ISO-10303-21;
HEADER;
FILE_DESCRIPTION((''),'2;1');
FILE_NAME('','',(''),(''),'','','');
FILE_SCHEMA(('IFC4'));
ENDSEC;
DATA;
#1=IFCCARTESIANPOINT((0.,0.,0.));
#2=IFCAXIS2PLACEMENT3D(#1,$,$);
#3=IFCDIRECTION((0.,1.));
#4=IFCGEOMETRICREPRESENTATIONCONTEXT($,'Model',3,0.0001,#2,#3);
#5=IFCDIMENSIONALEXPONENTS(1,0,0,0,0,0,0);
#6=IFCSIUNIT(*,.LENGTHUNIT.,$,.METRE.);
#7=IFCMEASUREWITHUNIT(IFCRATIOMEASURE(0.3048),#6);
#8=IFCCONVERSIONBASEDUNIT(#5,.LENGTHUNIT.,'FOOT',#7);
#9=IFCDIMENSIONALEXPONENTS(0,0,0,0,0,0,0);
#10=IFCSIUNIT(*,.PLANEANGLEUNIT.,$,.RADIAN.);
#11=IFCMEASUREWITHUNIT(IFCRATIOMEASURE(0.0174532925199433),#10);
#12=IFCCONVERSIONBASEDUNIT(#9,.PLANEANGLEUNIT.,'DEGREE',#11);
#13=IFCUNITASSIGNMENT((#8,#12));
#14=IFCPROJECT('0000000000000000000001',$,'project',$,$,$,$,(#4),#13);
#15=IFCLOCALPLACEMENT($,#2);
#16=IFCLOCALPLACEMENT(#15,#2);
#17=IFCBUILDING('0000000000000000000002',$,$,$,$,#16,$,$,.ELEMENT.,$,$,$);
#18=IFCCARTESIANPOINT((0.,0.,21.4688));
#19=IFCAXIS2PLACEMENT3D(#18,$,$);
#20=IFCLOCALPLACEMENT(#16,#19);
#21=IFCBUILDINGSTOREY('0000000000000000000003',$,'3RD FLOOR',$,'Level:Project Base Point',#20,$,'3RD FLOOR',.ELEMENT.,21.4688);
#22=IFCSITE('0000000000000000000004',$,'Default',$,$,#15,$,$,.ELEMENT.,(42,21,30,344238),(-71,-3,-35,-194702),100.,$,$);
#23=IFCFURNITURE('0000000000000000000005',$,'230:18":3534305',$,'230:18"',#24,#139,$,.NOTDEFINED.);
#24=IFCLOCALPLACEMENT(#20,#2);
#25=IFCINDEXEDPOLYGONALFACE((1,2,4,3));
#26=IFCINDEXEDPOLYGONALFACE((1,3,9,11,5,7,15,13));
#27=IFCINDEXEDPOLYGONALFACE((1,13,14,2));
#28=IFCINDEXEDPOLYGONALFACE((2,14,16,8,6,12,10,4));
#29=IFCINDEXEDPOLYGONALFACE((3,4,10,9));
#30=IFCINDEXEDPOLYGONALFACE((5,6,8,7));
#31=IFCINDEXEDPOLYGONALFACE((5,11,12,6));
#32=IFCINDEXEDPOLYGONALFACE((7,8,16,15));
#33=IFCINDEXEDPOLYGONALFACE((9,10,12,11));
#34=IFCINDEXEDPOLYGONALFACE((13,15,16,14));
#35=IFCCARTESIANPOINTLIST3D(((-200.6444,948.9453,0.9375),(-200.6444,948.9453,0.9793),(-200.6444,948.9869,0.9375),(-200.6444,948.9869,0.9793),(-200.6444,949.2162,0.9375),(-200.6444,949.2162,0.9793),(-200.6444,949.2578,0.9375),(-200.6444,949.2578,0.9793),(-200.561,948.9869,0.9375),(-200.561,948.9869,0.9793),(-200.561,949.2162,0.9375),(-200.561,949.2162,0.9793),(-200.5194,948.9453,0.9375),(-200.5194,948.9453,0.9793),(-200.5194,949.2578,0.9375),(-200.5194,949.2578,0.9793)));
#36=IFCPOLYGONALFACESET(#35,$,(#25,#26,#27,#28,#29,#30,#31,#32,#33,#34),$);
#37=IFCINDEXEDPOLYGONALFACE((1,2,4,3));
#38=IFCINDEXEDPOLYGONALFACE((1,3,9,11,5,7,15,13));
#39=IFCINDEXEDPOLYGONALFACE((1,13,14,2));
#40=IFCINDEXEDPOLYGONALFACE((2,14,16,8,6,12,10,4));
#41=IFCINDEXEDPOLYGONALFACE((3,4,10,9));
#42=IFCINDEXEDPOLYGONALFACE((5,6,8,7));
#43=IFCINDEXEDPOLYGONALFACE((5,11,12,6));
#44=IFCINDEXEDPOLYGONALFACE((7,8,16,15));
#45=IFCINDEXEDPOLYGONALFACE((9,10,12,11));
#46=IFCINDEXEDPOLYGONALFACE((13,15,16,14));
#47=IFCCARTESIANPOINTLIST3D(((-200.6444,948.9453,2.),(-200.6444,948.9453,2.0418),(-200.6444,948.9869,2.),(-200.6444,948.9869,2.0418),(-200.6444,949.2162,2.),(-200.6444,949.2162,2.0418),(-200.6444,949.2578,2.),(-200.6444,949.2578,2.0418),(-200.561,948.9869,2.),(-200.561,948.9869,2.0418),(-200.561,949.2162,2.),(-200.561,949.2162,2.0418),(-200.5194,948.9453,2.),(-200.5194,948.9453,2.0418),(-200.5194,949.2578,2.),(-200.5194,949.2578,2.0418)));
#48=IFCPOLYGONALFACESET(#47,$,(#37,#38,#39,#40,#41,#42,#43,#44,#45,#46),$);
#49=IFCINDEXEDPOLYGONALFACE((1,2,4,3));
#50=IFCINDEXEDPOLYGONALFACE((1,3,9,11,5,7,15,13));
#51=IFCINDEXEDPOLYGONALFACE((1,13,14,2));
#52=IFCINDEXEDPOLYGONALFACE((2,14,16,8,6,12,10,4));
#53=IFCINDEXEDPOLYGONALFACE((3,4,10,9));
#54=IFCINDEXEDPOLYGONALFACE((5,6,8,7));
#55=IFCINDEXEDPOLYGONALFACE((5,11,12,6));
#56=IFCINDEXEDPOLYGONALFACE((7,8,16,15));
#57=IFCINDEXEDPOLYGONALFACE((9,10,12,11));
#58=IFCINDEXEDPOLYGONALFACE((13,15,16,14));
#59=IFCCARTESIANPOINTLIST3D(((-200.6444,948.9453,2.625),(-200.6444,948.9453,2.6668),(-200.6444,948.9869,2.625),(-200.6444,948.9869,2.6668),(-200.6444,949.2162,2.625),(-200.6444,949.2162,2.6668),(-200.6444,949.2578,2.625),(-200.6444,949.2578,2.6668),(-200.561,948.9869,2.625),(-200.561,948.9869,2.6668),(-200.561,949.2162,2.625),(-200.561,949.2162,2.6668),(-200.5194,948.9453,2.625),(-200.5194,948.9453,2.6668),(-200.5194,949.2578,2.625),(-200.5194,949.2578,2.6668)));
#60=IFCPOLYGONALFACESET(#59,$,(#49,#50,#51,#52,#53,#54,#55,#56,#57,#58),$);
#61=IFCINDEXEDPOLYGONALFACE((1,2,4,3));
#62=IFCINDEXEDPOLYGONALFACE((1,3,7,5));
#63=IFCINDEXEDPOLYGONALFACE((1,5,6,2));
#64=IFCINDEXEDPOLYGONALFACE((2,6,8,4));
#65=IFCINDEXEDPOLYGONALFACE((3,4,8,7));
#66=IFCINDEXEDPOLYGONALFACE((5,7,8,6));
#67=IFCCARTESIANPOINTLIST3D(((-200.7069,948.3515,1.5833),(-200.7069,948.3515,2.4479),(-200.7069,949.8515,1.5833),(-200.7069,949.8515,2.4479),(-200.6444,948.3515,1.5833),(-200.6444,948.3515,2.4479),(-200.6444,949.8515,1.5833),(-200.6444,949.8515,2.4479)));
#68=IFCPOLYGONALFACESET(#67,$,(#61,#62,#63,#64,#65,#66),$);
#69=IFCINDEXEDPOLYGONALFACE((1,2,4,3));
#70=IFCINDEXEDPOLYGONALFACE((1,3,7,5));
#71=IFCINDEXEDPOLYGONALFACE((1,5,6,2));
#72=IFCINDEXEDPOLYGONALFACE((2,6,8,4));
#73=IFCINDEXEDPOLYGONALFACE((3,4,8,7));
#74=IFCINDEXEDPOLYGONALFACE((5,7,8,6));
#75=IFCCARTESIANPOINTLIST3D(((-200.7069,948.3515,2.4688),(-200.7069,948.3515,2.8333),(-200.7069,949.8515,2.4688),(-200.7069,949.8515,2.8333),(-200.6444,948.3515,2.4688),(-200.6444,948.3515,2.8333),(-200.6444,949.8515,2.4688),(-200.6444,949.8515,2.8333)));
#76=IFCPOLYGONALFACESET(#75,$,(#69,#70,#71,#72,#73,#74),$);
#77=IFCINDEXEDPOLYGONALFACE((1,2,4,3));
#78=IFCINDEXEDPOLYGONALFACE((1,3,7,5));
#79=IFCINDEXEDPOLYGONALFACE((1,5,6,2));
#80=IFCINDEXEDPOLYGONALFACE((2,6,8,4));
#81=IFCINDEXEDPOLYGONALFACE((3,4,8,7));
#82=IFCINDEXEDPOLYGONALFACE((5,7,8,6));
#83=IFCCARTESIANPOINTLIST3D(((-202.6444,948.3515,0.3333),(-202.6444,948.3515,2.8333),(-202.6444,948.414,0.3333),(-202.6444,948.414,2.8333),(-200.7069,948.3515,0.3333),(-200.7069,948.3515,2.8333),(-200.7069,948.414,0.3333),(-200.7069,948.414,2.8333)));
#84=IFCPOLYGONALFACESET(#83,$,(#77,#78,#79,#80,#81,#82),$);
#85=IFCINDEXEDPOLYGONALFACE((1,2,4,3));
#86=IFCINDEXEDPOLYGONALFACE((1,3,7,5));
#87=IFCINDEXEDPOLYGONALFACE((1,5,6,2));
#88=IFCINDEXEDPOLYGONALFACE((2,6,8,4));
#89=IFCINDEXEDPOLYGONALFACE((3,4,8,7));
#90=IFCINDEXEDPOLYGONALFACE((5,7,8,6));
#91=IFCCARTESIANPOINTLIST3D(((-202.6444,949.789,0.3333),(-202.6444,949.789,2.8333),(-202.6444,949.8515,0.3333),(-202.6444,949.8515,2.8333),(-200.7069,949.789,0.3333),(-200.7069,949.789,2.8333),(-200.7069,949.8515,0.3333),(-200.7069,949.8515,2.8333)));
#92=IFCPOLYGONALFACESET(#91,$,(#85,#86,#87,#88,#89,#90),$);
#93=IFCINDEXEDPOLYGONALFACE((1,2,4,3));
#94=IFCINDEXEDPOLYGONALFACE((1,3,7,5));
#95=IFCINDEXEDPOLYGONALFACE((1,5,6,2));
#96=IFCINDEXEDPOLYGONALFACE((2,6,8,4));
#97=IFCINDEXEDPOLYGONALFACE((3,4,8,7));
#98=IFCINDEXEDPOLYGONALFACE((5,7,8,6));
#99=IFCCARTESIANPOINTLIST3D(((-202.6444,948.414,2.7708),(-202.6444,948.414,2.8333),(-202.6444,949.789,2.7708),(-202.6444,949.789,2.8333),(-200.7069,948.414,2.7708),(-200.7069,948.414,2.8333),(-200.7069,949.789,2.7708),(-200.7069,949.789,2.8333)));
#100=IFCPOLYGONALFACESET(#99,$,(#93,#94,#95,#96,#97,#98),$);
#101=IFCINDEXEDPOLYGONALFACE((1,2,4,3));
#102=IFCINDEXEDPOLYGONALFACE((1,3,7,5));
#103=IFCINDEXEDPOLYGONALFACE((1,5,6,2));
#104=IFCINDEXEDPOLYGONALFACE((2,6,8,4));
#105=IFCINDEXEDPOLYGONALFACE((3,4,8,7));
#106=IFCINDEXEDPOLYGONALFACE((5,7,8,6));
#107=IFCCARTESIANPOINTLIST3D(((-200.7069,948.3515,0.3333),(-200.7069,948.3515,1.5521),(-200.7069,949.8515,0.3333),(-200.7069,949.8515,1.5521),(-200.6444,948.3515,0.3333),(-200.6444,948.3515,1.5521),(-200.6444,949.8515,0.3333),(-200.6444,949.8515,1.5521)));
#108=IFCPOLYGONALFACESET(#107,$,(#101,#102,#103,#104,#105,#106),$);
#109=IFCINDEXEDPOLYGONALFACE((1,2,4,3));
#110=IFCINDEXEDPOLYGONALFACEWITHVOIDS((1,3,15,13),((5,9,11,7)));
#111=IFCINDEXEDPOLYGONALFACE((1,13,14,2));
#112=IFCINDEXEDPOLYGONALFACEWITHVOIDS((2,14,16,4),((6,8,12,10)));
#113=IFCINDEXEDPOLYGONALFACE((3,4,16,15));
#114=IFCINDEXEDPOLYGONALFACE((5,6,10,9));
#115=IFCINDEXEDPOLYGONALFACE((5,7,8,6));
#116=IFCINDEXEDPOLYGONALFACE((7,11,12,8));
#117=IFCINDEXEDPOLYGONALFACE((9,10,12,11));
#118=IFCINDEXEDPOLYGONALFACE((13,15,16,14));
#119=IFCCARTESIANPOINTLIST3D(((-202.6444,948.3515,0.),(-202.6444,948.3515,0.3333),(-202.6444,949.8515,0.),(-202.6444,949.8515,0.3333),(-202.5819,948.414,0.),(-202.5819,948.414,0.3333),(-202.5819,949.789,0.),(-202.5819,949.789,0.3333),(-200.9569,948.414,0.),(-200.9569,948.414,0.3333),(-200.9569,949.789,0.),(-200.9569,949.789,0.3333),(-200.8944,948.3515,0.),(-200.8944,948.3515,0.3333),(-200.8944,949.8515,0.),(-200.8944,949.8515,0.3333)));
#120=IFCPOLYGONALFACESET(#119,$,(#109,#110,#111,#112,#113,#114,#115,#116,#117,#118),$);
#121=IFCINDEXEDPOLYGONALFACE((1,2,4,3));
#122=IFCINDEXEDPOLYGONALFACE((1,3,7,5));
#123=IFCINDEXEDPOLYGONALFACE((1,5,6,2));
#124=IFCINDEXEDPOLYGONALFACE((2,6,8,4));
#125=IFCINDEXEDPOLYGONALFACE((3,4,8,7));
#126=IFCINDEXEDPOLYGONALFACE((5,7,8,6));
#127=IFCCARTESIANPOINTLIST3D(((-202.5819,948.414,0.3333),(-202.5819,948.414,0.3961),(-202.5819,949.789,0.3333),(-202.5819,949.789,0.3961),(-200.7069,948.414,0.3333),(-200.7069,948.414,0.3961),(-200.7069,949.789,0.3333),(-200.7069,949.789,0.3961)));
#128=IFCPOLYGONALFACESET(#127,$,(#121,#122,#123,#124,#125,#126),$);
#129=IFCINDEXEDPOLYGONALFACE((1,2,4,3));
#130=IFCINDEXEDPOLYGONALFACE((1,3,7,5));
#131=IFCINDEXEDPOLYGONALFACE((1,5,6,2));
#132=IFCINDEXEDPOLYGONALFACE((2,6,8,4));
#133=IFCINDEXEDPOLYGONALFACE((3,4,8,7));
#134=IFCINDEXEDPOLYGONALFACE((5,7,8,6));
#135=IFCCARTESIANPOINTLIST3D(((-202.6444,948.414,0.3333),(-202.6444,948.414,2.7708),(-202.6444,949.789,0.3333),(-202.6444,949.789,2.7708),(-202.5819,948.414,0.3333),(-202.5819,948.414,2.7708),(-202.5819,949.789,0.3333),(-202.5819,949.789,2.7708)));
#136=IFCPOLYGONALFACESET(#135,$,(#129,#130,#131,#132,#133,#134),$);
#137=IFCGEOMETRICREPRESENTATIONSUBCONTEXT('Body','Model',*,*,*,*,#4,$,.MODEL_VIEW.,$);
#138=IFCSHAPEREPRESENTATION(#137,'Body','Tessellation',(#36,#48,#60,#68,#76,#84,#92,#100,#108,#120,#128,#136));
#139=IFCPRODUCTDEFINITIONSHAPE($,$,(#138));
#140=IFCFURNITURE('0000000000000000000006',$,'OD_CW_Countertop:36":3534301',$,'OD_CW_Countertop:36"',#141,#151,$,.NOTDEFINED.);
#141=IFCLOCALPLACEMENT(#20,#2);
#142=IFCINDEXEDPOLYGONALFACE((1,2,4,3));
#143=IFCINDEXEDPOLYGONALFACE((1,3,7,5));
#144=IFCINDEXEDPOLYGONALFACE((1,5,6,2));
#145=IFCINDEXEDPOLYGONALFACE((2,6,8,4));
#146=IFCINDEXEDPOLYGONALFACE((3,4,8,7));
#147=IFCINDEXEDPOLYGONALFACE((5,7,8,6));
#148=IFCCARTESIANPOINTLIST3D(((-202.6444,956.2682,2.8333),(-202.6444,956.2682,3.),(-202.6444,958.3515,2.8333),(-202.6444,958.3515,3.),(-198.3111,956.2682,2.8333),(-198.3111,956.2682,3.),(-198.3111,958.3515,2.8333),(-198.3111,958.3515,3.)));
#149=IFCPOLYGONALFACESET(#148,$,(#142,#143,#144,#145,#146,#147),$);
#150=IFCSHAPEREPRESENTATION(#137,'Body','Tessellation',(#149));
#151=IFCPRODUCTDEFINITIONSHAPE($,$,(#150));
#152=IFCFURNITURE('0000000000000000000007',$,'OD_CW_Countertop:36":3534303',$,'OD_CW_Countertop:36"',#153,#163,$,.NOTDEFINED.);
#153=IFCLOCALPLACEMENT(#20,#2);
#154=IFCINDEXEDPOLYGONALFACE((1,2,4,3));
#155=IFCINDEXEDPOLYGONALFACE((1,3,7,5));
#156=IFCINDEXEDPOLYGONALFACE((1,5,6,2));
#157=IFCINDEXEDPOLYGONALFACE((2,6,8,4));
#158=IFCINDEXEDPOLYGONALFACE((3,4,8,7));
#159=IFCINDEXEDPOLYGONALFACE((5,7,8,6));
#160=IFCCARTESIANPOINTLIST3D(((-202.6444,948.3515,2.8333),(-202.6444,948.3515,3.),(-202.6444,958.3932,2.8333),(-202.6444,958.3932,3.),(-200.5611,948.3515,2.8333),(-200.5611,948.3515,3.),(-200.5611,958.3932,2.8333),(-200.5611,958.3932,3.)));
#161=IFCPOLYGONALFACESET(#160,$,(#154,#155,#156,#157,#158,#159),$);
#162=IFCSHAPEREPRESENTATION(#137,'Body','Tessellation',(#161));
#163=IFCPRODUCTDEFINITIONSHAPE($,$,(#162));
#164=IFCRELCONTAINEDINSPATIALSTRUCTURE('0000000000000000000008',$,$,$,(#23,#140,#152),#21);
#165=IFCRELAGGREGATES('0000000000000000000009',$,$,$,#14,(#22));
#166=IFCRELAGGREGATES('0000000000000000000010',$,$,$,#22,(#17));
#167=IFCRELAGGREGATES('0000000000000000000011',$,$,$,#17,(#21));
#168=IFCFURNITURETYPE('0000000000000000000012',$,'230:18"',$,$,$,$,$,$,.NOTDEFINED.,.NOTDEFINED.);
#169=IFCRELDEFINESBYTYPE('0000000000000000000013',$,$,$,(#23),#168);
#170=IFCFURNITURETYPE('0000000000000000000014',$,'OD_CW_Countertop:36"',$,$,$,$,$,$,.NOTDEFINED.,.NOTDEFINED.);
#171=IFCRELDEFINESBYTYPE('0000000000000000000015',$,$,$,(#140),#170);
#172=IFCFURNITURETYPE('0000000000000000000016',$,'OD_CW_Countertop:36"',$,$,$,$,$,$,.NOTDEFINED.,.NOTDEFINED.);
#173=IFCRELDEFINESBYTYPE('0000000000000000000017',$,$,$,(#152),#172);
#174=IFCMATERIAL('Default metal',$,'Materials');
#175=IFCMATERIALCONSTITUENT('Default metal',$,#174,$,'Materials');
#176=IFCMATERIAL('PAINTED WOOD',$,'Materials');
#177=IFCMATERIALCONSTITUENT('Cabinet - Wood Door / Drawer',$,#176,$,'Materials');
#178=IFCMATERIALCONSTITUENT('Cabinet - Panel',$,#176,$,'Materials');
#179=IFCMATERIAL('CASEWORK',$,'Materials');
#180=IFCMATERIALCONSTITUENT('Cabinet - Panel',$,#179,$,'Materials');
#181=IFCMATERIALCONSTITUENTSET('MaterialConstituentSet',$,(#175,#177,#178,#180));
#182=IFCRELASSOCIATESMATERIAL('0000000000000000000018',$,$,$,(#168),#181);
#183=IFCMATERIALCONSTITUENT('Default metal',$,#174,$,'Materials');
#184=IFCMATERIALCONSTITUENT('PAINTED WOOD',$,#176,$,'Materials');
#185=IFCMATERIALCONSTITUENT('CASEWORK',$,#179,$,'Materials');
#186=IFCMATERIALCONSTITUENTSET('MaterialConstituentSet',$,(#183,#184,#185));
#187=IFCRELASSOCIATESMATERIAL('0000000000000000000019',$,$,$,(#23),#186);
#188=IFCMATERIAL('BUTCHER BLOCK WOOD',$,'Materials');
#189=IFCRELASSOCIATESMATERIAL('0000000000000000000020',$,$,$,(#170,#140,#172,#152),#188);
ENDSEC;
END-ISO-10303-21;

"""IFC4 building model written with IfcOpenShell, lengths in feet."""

from ifc_helpers import new_model, entity, si_unit, converted_unit, direction, frame, frame_2d, origin, origin_2d_with_axis, place, context, subcontext, project, spatial, polyline, rectangle, outline, extrude, source, transform, mapped, material, constituent, constituent_set, type_object, type_shapes, element, save


model = new_model("IFC4")

# Units and contexts
model_context = context("Model", 3, precision=0.0001, world=origin(), true_north=direction((0.0, 1.0)))
body_context = subcontext(model_context, "Body", "Model", "MODEL_VIEW")
ifc_project = project(units=[converted_unit("LENGTHUNIT", "FOOT", entity("IfcRatioMeasure", 0.3048), si_unit("LENGTHUNIT", "METRE"), dimensions=[1, 0, 0, 0, 0, 0, 0]), converted_unit("PLANEANGLEUNIT", "DEGREE", entity("IfcRatioMeasure", 0.0174532925199433), si_unit("PLANEANGLEUNIT", "RADIAN"), dimensions=[0, 0, 0, 0, 0, 0, 0])], contexts=[model_context])

# Site, building, storey
site_placement = place(None, origin())
site = spatial("IfcSite", under=ifc_project, at=site_placement, Name="Default", CompositionType="ELEMENT", RefLatitude=(42, 21, 30, 344238), RefLongitude=(-71, -3, -35, -194702), RefElevation=100.0)
building_placement = place(site_placement, origin())
building = spatial("IfcBuilding", under=site, at=building_placement, CompositionType="ELEMENT")
storey_placement = place(building_placement, frame((0.0, 0.0, 21.4688)))
storey = spatial("IfcBuildingStorey", under=building, at=storey_placement, Name="3RD FLOOR", ObjectType="Level:Project Base Point", LongName="3RD FLOOR", CompositionType="ELEMENT", Elevation=21.4688)

# Furniture
ifc_material_1 = material(Name="Default metal", Category="Materials")
ifc_material_2 = material(Name="PAINTED WOOD", Category="Materials")
ifc_material_3 = material(Name="CASEWORK", Category="Materials")
ifc_constituent_1 = constituent(ifc_material_1, Name="Default metal", Category="Materials")
ifc_constituent_2 = constituent(ifc_material_2, Name="PAINTED WOOD", Category="Materials")
ifc_constituent_3 = constituent(ifc_material_3, Name="CASEWORK", Category="Materials")
ifc_constituent_set_1 = constituent_set(constituents=[ifc_constituent_1, ifc_constituent_2, ifc_constituent_3], Name="MaterialConstituentSet")
ifc_constituent_4 = constituent(ifc_material_1, Name="Default metal", Category="Materials")
ifc_constituent_5 = constituent(ifc_material_2, Name="Cabinet - Wood Door / Drawer", Category="Materials")
ifc_constituent_6 = constituent(ifc_material_2, Name="Cabinet - Panel", Category="Materials")
ifc_constituent_7 = constituent(ifc_material_3, Name="Cabinet - Panel", Category="Materials")
ifc_constituent_set_2 = constituent_set(constituents=[ifc_constituent_4, ifc_constituent_5, ifc_constituent_6, ifc_constituent_7], Name="MaterialConstituentSet")
furniture_type_1 = type_object("IfcFurnitureType", Name="230:18\"", AssemblyPlace="NOTDEFINED", PredefinedType="NOTDEFINED", material=ifc_constituent_set_2)
shared_shape_1 = source(origin(), body_context, "Body", "SweptSolid", [
    extrude(outline(polyline([(-0.0521, -0.1562), (0.0729, -0.1562), (0.0729, 0.1562), (-0.0521, 0.1562), (-0.0521, 0.1146), (0.0313, 0.1146), (0.0313, -0.1146), (-0.0521, -0.1146), (-0.0521, -0.1562)])), frame((0.0615, -2.0521, 0.9375), z_axis=(0.0, 0.0, 1.0), x_axis=(0.0, -1.0, 0.0)), (0.0, 0.0, 1.0), 0.0418),
    extrude(outline(polyline([(-0.0521, -0.1562), (0.0729, -0.1562), (0.0729, 0.1562), (-0.0521, 0.1562), (-0.0521, 0.1146), (0.0313, 0.1146), (0.0313, -0.1146), (-0.0521, -0.1146), (-0.0521, -0.1562)])), frame((0.0615, -2.0521, 2.0), z_axis=(0.0, 0.0, 1.0), x_axis=(0.0, -1.0, 0.0)), (0.0, 0.0, 1.0), 0.0418),
    extrude(outline(polyline([(-0.0521, -0.1562), (0.0729, -0.1562), (0.0729, 0.1562), (-0.0521, 0.1562), (-0.0521, 0.1146), (0.0313, 0.1146), (0.0313, -0.1146), (-0.0521, -0.1146), (-0.0521, -0.1562)])), frame((0.0615, -2.0521, 2.625), z_axis=(0.0, 0.0, 1.0), x_axis=(0.0, -1.0, 0.0)), (0.0, 0.0, 1.0), 0.0418),
    extrude(rectangle(XDim=0.0625, YDim=1.5, at=frame_2d((0.0, 0.0), x_axis=(1.0, 0.0))), frame((0.0615, -1.9688, 1.5833), z_axis=(0.0, 0.0, 1.0), x_axis=(0.0, 1.0, 0.0)), (0.0, 0.0, 1.0), 0.8646),
    extrude(rectangle(XDim=0.0625, YDim=1.5, at=frame_2d((0.0, 0.0), x_axis=(1.0, 0.0))), frame((0.0615, -1.9688, 2.4688), z_axis=(0.0, 0.0, 1.0), x_axis=(0.0, 1.0, 0.0)), (0.0, 0.0, 1.0), 0.3646),
    extrude(rectangle(XDim=0.0625, YDim=1.9375, at=frame_2d((0.0, 0.0), x_axis=(1.0, 0.0))), frame((-0.6573, -0.9687, 0.3333)), (0.0, 0.0, 1.0), 2.5),
    extrude(rectangle(XDim=0.0625, YDim=1.9375, at=frame_2d((0.0, 0.0), x_axis=(1.0, 0.0))), frame((0.7802, -0.9687, 0.3333)), (0.0, 0.0, 1.0), 2.5),
    extrude(rectangle(XDim=1.375, YDim=1.9375, at=origin_2d_with_axis()), frame((0.0615, -0.9687, 2.7708), z_axis=(0.0, 0.0, 1.0), x_axis=(-1.0, 0.0, 0.0)), (0.0, 0.0, 1.0), 0.0625),
    extrude(rectangle(XDim=0.0625, YDim=1.5, at=frame_2d((0.0, 0.0), x_axis=(1.0, 0.0))), frame((0.0615, -1.9688, 0.3333), z_axis=(0.0, 0.0, 1.0), x_axis=(0.0, 1.0, 0.0)), (0.0, 0.0, 1.0), 1.2187),
    extrude(outline(polyline([(-0.75, -0.875), (0.75, -0.875), (0.75, 0.875), (-0.75, 0.875), (-0.75, -0.875)]), holes=[polyline([(-0.6875, -0.8125), (-0.6875, 0.8125), (0.6875, 0.8125), (0.6875, -0.8125), (-0.6875, -0.8125)])]), frame((0.0615, -0.875, 0.0)), (0.0, 0.0, 1.0), 0.3333),
    extrude(rectangle(XDim=1.375, YDim=1.875, at=frame_2d((0.0, 0.0), x_axis=(1.0, 0.0))), frame((0.0615, -1.0, 0.3333), z_axis=(0.0, 0.0, 1.0), x_axis=(-1.0, 0.0, 0.0)), (0.0, 0.0, 1.0), 0.0627),
    extrude(rectangle(XDim=0.0625, YDim=1.375, at=origin_2d_with_axis()), frame((0.0615, -0.0312, 0.3333), z_axis=(0.0, 0.0, 1.0), x_axis=(0.0, 1.0, 0.0)), (0.0, 0.0, 1.0), 2.4375),
])
type_shapes(furniture_type_1, [shared_shape_1])
furniture_1_placement = place(storey_placement, frame((-202.6444, 949.04, 0.0), z_axis=(0.0, 0.0, 1.0), x_axis=(0.0, 1.0, 0.0)))
element("IfcFurniture", 1, at=furniture_1_placement, inside=storey, type_object=furniture_type_1, material=ifc_constituent_set_1, Name="230:18\":3534305", ObjectType="230:18\"", PredefinedType="NOTDEFINED", context=body_context, shape_type="MappedRepresentation", body=[
    mapped(shared_shape_1, transform((0.0, 0.0, 0.0), scale=1.0)),
])
ifc_material_4 = material(Name="BUTCHER BLOCK WOOD", Category="Materials")
furniture_type_2 = type_object("IfcFurnitureType", Name="OD_CW_Countertop:36\"", AssemblyPlace="NOTDEFINED", PredefinedType="NOTDEFINED", material=ifc_material_4)
shared_shape_2 = source(origin(), body_context, "Body", "SweptSolid", [
    extrude(rectangle(XDim=4.3333, YDim=2.0833, at=origin_2d_with_axis()), frame((2.1667, 1.0417, 0.0)), (0.0, 0.0, 1.0), 0.1667),
])
type_shapes(furniture_type_2, [shared_shape_2])
furniture_2_placement = place(storey_placement, frame((-198.3111, 958.3515, 2.8333), z_axis=(0.0, 0.0, 1.0), x_axis=(-1.0, 0.0, 0.0)))
element("IfcFurniture", 2, at=furniture_2_placement, inside=storey, type_object=furniture_type_2, material=ifc_material_4, Name="OD_CW_Countertop:36\":3534301", ObjectType="OD_CW_Countertop:36\"", PredefinedType="NOTDEFINED", context=body_context, shape_type="MappedRepresentation", body=[
    mapped(shared_shape_2, transform((0.0, 0.0, 0.0), scale=1.0)),
])
furniture_type_3 = type_object("IfcFurnitureType", Name="OD_CW_Countertop:36\"", AssemblyPlace="NOTDEFINED", PredefinedType="NOTDEFINED", material=ifc_material_4)
shared_shape_3 = source(origin(), body_context, "Body", "SweptSolid", [
    extrude(rectangle(XDim=10.0417, YDim=2.0833, at=origin_2d_with_axis()), frame((5.0208, 1.0417, 0.0)), (0.0, 0.0, 1.0), 0.1667),
])
type_shapes(furniture_type_3, [shared_shape_3])
furniture_3_placement = place(storey_placement, frame((-202.6444, 958.3932, 2.8333), z_axis=(0.0, 0.0, 1.0), x_axis=(0.0, -1.0, 0.0)))
element("IfcFurniture", 3, at=furniture_3_placement, inside=storey, type_object=furniture_type_3, material=ifc_material_4, Name="OD_CW_Countertop:36\":3534303", ObjectType="OD_CW_Countertop:36\"", PredefinedType="NOTDEFINED", context=body_context, shape_type="MappedRepresentation", body=[
    mapped(shared_shape_3, transform((0.0, 0.0, 0.0), scale=1.0)),
])

save(model, "model.ifc")
